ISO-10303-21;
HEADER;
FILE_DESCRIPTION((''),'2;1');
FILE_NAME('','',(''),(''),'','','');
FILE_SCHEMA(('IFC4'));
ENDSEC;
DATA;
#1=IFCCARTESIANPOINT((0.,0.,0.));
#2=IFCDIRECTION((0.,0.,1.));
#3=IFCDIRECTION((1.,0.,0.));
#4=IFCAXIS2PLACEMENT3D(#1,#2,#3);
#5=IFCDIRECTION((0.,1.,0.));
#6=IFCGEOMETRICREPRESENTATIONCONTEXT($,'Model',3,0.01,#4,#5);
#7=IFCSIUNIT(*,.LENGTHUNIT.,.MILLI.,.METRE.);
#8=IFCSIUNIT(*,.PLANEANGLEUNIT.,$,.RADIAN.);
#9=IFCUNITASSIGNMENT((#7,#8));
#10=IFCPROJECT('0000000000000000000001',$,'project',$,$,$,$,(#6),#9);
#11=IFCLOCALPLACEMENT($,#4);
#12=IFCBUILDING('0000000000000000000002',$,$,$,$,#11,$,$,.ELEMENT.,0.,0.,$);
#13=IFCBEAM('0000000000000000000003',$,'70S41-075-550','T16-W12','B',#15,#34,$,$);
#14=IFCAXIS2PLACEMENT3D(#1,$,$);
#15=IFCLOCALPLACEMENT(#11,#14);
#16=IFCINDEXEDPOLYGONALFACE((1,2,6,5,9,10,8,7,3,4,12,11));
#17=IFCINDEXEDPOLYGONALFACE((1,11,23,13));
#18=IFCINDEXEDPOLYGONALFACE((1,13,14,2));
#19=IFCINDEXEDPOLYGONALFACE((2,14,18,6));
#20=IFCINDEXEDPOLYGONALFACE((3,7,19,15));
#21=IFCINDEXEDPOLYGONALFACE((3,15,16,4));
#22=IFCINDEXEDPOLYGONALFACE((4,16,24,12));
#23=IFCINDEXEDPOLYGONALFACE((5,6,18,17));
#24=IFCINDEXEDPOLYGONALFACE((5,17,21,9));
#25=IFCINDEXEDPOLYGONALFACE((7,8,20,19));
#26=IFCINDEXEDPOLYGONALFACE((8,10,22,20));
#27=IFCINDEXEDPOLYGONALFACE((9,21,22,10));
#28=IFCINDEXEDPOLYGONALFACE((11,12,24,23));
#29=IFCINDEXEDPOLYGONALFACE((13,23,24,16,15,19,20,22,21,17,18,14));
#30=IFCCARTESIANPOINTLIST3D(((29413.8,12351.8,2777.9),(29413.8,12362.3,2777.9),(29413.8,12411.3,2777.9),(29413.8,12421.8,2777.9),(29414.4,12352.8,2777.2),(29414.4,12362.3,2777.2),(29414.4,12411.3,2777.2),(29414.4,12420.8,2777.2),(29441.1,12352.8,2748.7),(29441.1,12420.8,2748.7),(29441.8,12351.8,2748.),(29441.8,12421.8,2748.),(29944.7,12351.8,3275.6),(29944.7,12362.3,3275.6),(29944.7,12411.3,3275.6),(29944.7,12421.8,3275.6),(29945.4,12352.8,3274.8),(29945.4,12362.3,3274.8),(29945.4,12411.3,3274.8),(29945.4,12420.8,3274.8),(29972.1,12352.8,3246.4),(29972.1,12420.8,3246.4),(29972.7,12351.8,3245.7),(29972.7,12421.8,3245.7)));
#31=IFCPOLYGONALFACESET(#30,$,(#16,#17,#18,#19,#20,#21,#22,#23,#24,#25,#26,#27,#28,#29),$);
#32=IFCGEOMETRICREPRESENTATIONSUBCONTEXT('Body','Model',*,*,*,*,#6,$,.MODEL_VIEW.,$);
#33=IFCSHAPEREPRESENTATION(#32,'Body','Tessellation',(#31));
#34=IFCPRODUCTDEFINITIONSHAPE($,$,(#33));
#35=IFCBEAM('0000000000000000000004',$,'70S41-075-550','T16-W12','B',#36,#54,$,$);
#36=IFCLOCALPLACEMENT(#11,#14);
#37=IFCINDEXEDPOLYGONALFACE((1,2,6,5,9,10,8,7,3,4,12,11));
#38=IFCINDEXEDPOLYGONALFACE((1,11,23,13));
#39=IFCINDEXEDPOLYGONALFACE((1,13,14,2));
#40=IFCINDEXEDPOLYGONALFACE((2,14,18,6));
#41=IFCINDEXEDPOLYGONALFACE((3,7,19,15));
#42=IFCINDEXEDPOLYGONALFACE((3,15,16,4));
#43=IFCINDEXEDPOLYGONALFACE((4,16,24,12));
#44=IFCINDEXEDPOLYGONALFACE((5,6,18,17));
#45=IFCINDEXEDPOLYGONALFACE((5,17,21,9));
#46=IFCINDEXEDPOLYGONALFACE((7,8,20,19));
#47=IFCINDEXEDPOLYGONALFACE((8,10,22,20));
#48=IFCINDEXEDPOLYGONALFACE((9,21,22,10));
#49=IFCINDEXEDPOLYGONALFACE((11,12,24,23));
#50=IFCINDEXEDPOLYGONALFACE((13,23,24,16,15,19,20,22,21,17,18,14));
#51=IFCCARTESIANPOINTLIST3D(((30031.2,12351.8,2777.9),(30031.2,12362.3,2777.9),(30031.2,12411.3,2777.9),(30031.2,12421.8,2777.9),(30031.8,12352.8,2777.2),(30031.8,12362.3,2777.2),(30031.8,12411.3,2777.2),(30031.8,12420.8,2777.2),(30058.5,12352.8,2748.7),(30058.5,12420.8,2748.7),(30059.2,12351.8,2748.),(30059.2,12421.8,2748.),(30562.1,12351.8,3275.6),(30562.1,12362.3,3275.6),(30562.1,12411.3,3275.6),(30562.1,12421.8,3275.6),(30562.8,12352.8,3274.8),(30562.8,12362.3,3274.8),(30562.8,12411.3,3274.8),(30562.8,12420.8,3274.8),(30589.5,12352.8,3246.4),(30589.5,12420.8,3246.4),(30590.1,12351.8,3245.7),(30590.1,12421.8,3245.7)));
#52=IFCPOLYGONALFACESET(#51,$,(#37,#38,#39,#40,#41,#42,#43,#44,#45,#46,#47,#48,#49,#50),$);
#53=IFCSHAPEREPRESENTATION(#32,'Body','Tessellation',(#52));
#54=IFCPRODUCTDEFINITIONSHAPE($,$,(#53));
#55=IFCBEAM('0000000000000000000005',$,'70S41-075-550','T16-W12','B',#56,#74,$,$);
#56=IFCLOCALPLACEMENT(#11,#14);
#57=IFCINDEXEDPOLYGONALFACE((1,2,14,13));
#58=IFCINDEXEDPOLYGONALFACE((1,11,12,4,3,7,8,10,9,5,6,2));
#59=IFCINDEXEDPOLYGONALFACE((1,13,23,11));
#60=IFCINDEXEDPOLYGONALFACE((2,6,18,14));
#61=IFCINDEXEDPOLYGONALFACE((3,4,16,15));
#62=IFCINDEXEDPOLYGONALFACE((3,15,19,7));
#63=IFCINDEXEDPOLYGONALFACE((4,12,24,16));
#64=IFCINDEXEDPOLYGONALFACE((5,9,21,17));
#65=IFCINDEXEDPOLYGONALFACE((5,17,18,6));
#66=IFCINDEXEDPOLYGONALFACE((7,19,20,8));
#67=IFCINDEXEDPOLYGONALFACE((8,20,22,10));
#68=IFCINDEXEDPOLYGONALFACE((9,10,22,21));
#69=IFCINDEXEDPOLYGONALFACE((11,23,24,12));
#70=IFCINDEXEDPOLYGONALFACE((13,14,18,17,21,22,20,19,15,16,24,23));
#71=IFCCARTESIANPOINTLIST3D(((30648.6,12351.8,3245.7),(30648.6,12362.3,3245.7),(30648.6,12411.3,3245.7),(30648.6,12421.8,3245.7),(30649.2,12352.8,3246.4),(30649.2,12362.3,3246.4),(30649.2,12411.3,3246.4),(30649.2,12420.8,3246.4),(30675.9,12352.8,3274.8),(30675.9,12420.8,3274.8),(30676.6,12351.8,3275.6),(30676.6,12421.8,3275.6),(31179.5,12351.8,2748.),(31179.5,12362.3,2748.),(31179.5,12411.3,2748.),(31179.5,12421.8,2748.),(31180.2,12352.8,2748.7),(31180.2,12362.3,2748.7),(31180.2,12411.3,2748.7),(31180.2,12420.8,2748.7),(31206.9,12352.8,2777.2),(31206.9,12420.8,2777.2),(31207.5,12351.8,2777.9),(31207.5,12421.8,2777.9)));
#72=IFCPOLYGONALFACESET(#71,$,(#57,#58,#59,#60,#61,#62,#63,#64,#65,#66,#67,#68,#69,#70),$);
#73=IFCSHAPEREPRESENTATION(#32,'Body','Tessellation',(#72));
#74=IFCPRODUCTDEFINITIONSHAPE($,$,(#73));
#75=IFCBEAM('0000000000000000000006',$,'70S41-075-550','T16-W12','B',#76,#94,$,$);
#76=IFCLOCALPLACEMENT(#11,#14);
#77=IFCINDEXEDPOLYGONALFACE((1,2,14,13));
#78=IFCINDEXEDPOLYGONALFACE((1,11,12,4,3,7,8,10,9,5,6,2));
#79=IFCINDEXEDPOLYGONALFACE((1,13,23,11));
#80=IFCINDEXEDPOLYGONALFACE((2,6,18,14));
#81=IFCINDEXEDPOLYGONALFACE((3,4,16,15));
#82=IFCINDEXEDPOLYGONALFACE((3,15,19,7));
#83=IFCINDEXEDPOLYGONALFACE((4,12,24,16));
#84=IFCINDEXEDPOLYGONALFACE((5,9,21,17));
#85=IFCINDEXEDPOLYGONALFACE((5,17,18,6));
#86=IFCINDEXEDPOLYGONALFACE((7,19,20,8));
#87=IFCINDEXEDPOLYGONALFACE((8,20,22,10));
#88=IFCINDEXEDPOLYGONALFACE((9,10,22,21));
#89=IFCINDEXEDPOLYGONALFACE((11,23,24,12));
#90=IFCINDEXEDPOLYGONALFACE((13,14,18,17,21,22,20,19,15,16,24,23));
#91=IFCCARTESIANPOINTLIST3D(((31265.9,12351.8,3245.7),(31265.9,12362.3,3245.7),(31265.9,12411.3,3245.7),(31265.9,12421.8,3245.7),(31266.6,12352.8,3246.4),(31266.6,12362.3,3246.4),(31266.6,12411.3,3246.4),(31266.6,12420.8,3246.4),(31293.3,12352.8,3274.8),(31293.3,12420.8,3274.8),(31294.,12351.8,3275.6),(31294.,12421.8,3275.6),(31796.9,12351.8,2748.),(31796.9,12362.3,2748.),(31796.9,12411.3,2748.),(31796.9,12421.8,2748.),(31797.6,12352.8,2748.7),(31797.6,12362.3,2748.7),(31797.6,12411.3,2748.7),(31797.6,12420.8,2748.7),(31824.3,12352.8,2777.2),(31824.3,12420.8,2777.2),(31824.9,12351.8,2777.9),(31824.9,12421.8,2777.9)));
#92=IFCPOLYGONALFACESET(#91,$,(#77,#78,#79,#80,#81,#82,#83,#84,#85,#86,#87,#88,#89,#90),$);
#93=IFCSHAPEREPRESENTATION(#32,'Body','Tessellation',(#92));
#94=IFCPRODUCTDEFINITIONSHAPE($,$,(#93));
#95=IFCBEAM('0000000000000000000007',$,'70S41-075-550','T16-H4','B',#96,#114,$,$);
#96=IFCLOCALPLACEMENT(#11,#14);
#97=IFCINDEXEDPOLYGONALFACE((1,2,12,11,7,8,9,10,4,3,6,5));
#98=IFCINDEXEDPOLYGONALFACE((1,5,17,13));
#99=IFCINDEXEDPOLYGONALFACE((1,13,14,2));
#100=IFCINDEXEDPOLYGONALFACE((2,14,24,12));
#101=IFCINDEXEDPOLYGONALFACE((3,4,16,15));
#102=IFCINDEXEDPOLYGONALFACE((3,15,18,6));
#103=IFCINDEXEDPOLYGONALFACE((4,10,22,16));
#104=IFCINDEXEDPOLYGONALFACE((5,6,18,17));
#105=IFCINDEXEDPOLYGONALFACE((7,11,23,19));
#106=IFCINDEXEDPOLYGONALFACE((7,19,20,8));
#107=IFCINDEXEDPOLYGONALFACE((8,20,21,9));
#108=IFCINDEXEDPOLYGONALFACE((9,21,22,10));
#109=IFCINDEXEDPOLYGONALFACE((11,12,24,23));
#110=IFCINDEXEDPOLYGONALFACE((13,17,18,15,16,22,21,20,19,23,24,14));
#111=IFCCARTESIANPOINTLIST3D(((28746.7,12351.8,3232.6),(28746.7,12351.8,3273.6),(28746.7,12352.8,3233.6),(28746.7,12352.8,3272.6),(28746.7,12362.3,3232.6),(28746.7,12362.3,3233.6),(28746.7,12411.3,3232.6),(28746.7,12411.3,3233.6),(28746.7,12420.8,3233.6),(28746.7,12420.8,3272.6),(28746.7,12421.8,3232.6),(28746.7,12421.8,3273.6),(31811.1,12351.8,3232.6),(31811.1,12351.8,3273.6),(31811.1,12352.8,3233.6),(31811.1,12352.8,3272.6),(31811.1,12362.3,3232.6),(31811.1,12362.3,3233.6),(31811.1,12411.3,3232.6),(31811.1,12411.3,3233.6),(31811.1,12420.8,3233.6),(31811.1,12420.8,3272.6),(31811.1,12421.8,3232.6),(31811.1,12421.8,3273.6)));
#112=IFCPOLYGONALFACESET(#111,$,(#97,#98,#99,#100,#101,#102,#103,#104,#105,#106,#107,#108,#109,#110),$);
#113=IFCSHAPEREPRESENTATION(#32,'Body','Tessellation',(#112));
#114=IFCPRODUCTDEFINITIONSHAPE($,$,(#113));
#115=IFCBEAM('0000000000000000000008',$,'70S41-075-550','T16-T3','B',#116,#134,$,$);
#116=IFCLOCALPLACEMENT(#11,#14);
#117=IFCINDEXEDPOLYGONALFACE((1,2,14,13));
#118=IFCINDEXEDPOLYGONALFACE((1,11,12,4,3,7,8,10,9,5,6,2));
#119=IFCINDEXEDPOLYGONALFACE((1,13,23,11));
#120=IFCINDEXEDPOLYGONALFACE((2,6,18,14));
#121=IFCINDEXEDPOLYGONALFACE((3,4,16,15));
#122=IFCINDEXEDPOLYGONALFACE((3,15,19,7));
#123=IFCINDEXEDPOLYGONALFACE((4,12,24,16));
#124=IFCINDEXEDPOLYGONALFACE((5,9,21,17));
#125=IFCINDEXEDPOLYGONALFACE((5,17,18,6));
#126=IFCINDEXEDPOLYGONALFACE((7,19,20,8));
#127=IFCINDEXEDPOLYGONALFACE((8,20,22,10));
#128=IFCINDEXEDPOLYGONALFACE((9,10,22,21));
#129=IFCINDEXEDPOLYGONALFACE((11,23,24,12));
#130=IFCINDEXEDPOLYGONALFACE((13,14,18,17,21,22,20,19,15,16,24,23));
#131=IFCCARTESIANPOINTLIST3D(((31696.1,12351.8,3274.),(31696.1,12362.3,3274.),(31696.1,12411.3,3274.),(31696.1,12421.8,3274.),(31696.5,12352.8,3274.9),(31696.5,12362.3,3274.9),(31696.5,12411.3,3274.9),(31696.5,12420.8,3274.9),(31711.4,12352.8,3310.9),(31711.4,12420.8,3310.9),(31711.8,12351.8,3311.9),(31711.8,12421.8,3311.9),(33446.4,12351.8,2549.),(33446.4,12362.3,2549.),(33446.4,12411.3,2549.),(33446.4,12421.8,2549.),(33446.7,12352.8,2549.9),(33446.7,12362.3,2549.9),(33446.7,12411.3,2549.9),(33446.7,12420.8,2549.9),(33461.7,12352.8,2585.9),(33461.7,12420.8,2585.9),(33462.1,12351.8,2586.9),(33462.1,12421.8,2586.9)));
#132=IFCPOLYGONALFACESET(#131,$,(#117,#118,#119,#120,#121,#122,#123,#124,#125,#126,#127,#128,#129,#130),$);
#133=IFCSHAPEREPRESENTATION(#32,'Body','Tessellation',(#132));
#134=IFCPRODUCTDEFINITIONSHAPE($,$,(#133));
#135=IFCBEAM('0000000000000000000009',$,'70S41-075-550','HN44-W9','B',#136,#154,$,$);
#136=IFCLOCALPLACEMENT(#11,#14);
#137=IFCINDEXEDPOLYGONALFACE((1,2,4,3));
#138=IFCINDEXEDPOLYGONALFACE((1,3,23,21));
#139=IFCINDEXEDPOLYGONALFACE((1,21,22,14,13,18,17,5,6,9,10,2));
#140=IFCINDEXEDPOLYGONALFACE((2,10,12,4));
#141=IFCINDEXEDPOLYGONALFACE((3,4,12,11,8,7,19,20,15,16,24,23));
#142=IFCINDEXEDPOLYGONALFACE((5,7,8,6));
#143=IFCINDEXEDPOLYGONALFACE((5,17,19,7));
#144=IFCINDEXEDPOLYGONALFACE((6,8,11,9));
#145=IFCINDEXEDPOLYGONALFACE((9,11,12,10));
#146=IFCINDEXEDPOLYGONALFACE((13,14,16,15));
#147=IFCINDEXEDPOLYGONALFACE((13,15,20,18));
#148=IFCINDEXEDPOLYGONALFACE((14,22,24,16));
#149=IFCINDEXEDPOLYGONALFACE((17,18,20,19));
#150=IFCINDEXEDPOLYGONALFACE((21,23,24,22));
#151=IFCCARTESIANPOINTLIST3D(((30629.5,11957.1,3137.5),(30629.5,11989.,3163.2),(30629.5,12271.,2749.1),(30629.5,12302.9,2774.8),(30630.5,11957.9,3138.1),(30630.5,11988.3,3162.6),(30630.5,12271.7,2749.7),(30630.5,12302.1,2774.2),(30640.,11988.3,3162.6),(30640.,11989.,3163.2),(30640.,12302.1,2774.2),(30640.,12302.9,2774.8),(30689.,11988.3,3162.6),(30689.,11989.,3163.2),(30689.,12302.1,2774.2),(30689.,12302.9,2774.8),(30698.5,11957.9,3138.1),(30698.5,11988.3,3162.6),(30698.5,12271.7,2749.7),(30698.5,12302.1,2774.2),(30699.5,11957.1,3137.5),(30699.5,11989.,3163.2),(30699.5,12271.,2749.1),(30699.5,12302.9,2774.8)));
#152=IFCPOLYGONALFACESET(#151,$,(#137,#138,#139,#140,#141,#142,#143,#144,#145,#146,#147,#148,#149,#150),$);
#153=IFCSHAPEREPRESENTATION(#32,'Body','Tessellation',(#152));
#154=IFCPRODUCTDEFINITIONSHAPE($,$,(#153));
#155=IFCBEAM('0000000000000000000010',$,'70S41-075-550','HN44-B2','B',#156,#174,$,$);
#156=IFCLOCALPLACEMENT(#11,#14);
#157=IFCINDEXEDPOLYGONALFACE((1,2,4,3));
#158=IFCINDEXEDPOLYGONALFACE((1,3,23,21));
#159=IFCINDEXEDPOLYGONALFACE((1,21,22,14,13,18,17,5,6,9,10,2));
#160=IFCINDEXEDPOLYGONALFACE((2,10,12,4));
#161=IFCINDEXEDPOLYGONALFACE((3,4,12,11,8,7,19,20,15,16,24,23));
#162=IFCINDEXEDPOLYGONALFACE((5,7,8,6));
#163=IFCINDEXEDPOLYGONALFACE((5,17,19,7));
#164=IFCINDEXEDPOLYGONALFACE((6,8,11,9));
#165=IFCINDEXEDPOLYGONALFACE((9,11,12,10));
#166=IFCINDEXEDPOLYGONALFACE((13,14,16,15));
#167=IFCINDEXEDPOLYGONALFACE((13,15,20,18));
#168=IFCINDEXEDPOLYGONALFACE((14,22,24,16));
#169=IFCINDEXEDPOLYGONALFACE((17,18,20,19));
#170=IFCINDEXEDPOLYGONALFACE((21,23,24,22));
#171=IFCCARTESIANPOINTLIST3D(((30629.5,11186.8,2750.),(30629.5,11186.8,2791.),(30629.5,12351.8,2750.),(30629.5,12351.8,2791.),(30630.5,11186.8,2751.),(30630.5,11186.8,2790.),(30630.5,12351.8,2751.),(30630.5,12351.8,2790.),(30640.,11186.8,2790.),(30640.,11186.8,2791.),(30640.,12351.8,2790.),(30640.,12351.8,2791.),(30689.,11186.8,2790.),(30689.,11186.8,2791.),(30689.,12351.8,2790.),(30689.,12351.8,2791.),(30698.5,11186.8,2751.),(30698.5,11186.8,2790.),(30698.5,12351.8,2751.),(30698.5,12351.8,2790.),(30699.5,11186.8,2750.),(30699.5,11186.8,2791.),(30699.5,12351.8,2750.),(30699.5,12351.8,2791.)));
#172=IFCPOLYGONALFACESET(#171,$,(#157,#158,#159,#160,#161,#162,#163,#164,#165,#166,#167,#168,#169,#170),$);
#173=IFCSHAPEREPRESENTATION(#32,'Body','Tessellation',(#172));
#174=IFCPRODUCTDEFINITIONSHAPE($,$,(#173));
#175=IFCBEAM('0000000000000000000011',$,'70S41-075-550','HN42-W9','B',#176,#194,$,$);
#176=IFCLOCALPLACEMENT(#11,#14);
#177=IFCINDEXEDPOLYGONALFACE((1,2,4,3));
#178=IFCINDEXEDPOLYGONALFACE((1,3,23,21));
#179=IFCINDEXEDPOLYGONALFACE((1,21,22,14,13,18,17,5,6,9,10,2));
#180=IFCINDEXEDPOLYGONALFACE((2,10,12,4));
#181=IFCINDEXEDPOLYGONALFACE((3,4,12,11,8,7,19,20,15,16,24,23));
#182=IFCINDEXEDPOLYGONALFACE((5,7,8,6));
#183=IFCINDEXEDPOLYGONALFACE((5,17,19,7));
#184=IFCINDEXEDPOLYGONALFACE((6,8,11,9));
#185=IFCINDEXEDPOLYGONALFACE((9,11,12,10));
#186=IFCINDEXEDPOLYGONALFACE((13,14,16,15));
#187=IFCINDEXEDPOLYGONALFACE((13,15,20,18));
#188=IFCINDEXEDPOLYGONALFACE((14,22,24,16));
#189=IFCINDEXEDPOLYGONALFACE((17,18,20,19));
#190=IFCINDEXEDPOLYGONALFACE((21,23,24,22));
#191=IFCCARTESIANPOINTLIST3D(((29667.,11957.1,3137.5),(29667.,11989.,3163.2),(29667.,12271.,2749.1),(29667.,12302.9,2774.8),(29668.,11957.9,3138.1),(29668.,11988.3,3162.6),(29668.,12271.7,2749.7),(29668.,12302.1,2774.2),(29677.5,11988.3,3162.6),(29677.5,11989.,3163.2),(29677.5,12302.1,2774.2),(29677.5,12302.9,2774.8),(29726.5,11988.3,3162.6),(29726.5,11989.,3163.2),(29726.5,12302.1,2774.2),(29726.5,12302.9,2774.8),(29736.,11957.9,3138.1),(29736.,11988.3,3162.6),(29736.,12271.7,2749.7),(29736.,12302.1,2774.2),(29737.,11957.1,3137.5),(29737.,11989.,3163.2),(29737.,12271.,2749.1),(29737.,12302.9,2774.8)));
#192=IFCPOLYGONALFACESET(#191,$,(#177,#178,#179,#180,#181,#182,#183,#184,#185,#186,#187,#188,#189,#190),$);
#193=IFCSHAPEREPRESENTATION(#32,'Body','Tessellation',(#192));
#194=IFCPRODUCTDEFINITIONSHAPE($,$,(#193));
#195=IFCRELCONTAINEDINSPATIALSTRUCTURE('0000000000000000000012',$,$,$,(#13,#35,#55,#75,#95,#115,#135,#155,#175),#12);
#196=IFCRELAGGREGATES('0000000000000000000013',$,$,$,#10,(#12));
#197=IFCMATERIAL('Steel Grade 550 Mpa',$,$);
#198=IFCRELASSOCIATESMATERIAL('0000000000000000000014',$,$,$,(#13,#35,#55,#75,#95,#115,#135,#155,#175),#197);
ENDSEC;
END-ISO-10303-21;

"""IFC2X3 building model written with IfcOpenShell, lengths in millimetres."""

from ifc_helpers import new_model, si_unit, direction, frame, origin, origin_with_axes, origin_2d_with_axis, place, context, subcontext, project, spatial, c_section, extrude, source, transform, mapped, material, element, save


model = new_model("IFC2X3")

# Units and contexts
model_context = context("Model", 3, precision=0.01, world=origin_with_axes(), true_north=direction((0.0, 1.0, 0.0)))
body_context = subcontext(model_context, "Body", "Model", "MODEL_VIEW")
ifc_project = project(units=[si_unit("LENGTHUNIT", "METRE", prefix="MILLI"), si_unit("PLANEANGLEUNIT", "RADIAN")], contexts=[model_context])

# Building
building_placement = place(None, origin_with_axes())
building = spatial("IfcBuilding", under=ifc_project, at=building_placement, CompositionType="ELEMENT", ElevationOfRefHeight=0.0, ElevationOfTerrain=0.0)

# Shared definitions
ifc_material = material(Name="Steel Grade 550 Mpa")

# Beams
shared_shape_1 = source(origin(), body_context, "Body", "SweptSolid", [
    extrude(c_section(Depth=70.0, Width=41.0, WallThickness=1.0, Girth=10.5, at=origin_2d_with_axis()), origin_with_axes(), (0.0, 0.0, 1.0), 727.7),
])
beam_1_placement = place(None, frame((29958.7, 12386.8, 3260.6), z_axis=(-0.72962, 0.0, -0.683853), x_axis=(-0.683853, 0.0, 0.72962)))
element("IfcBeam", 1, at=beam_1_placement, inside=building, material=ifc_material, Name="70S41-075-550", Description="T16-W12", ObjectType="B", context=body_context, shape_type="MappedRepresentation", body=[
    mapped(shared_shape_1, transform((0.0, 0.0, 0.0), scale=1.0)),
])
shared_shape_2 = source(origin(), body_context, "Body", "SweptSolid", [
    extrude(c_section(Depth=70.0, Width=41.0, WallThickness=1.0, Girth=10.5, at=origin_2d_with_axis()), origin_with_axes(), (0.0, 0.0, 1.0), 727.7),
])
beam_2_placement = place(None, frame((30576.1, 12386.8, 3260.6), z_axis=(-0.72962, 0.0, -0.683853), x_axis=(-0.683853, 0.0, 0.72962)))
element("IfcBeam", 2, at=beam_2_placement, inside=building, material=ifc_material, Name="70S41-075-550", Description="T16-W12", ObjectType="B", context=body_context, shape_type="MappedRepresentation", body=[
    mapped(shared_shape_2, transform((0.0, 0.0, 0.0), scale=1.0)),
])
shared_shape_3 = source(origin(), body_context, "Body", "SweptSolid", [
    extrude(c_section(Depth=70.0, Width=41.0, WallThickness=1.0, Girth=10.5, at=origin_2d_with_axis()), origin_with_axes(), (0.0, 0.0, 1.0), 727.7),
])
beam_3_placement = place(None, frame((30662.6, 12386.8, 3260.6), z_axis=(0.72962, 0.0, -0.683853), x_axis=(-0.683853, 0.0, -0.72962)))
element("IfcBeam", 3, at=beam_3_placement, inside=building, material=ifc_material, Name="70S41-075-550", Description="T16-W12", ObjectType="B", context=body_context, shape_type="MappedRepresentation", body=[
    mapped(shared_shape_3, transform((0.0, 0.0, 0.0), scale=1.0)),
])
shared_shape_4 = source(origin(), body_context, "Body", "SweptSolid", [
    extrude(c_section(Depth=70.0, Width=41.0, WallThickness=1.0, Girth=10.5, at=origin_2d_with_axis()), origin_with_axes(), (0.0, 0.0, 1.0), 727.7),
])
beam_4_placement = place(None, frame((31280.0, 12386.8, 3260.6), z_axis=(0.72962, 0.0, -0.683853), x_axis=(-0.683853, 0.0, -0.72962)))
element("IfcBeam", 4, at=beam_4_placement, inside=building, material=ifc_material, Name="70S41-075-550", Description="T16-W12", ObjectType="B", context=body_context, shape_type="MappedRepresentation", body=[
    mapped(shared_shape_4, transform((0.0, 0.0, 0.0), scale=1.0)),
])
shared_shape_5 = source(origin(), body_context, "Body", "SweptSolid", [
    extrude(c_section(Depth=70.0, Width=41.0, WallThickness=1.0, Girth=10.5, at=origin_2d_with_axis()), origin_with_axes(), (0.0, 0.0, 1.0), 3064.4),
])
beam_5_placement = place(None, frame((28746.7, 12386.8, 3253.1), z_axis=(1.0, 0.0, 0.0), x_axis=(0.0, 0.0, -1.0)))
element("IfcBeam", 5, at=beam_5_placement, inside=building, material=ifc_material, Name="70S41-075-550", Description="T16-H4", ObjectType="B", context=body_context, shape_type="MappedRepresentation", body=[
    mapped(shared_shape_5, transform((0.0, 0.0, 0.0), scale=1.0)),
])
shared_shape_6 = source(origin(), body_context, "Body", "SweptSolid", [
    extrude(c_section(Depth=70.0, Width=41.0, WallThickness=1.0, Girth=10.5, at=origin_2d_with_axis()), origin_with_axes(), (0.0, 0.0, 1.0), 1894.5),
])
beam_6_placement = place(None, frame((31703.9, 12386.8, 3292.9), z_axis=(0.92388, 0.0, -0.382683), x_axis=(-0.382683, 0.0, -0.92388)))
element("IfcBeam", 6, at=beam_6_placement, inside=building, material=ifc_material, Name="70S41-075-550", Description="T16-T3", ObjectType="B", context=body_context, shape_type="MappedRepresentation", body=[
    mapped(shared_shape_6, transform((0.0, 0.0, 0.0), scale=1.0)),
])
shared_shape_7 = source(origin(), body_context, "Body", "SweptSolid", [
    extrude(c_section(Depth=70.0, Width=41.0, WallThickness=1.0, Girth=10.5, at=origin_2d_with_axis()), origin_with_axes(), (0.0, 0.0, 1.0), 499.3),
])
beam_7_placement = place(None, frame((30664.5, 11973.1, 3150.3), z_axis=(0.0, 0.628483, -0.777823), x_axis=(0.0, 0.777823, 0.628483)))
element("IfcBeam", 7, at=beam_7_placement, inside=building, material=ifc_material, Name="70S41-075-550", Description="HN44-W9", ObjectType="B", context=body_context, shape_type="MappedRepresentation", body=[
    mapped(shared_shape_7, transform((0.0, 0.0, 0.0), scale=1.0)),
])
shared_shape_8 = source(origin(), body_context, "Body", "SweptSolid", [
    extrude(c_section(Depth=70.0, Width=41.0, WallThickness=1.0, Girth=10.5, at=origin_2d_with_axis()), origin_with_axes(), (0.0, 0.0, 1.0), 1165.0),
])
beam_8_placement = place(None, frame((30664.5, 11186.8, 2770.5), z_axis=(0.0, 1.0, 0.0), x_axis=(0.0, 0.0, 1.0)))
element("IfcBeam", 8, at=beam_8_placement, inside=building, material=ifc_material, Name="70S41-075-550", Description="HN44-B2", ObjectType="B", context=body_context, shape_type="MappedRepresentation", body=[
    mapped(shared_shape_8, transform((0.0, 0.0, 0.0), scale=1.0)),
])
shared_shape_9 = source(origin(), body_context, "Body", "SweptSolid", [
    extrude(c_section(Depth=70.0, Width=41.0, WallThickness=1.0, Girth=10.5, at=origin_2d_with_axis()), origin_with_axes(), (0.0, 0.0, 1.0), 499.3),
])
beam_9_placement = place(None, frame((29702.0, 11973.1, 3150.3), z_axis=(0.0, 0.628483, -0.777823), x_axis=(0.0, 0.777823, 0.628483)))
element("IfcBeam", 9, at=beam_9_placement, inside=building, material=ifc_material, Name="70S41-075-550", Description="HN42-W9", ObjectType="B", context=body_context, shape_type="MappedRepresentation", body=[
    mapped(shared_shape_9, transform((0.0, 0.0, 0.0), scale=1.0)),
])

save(model, "model.ifc")
